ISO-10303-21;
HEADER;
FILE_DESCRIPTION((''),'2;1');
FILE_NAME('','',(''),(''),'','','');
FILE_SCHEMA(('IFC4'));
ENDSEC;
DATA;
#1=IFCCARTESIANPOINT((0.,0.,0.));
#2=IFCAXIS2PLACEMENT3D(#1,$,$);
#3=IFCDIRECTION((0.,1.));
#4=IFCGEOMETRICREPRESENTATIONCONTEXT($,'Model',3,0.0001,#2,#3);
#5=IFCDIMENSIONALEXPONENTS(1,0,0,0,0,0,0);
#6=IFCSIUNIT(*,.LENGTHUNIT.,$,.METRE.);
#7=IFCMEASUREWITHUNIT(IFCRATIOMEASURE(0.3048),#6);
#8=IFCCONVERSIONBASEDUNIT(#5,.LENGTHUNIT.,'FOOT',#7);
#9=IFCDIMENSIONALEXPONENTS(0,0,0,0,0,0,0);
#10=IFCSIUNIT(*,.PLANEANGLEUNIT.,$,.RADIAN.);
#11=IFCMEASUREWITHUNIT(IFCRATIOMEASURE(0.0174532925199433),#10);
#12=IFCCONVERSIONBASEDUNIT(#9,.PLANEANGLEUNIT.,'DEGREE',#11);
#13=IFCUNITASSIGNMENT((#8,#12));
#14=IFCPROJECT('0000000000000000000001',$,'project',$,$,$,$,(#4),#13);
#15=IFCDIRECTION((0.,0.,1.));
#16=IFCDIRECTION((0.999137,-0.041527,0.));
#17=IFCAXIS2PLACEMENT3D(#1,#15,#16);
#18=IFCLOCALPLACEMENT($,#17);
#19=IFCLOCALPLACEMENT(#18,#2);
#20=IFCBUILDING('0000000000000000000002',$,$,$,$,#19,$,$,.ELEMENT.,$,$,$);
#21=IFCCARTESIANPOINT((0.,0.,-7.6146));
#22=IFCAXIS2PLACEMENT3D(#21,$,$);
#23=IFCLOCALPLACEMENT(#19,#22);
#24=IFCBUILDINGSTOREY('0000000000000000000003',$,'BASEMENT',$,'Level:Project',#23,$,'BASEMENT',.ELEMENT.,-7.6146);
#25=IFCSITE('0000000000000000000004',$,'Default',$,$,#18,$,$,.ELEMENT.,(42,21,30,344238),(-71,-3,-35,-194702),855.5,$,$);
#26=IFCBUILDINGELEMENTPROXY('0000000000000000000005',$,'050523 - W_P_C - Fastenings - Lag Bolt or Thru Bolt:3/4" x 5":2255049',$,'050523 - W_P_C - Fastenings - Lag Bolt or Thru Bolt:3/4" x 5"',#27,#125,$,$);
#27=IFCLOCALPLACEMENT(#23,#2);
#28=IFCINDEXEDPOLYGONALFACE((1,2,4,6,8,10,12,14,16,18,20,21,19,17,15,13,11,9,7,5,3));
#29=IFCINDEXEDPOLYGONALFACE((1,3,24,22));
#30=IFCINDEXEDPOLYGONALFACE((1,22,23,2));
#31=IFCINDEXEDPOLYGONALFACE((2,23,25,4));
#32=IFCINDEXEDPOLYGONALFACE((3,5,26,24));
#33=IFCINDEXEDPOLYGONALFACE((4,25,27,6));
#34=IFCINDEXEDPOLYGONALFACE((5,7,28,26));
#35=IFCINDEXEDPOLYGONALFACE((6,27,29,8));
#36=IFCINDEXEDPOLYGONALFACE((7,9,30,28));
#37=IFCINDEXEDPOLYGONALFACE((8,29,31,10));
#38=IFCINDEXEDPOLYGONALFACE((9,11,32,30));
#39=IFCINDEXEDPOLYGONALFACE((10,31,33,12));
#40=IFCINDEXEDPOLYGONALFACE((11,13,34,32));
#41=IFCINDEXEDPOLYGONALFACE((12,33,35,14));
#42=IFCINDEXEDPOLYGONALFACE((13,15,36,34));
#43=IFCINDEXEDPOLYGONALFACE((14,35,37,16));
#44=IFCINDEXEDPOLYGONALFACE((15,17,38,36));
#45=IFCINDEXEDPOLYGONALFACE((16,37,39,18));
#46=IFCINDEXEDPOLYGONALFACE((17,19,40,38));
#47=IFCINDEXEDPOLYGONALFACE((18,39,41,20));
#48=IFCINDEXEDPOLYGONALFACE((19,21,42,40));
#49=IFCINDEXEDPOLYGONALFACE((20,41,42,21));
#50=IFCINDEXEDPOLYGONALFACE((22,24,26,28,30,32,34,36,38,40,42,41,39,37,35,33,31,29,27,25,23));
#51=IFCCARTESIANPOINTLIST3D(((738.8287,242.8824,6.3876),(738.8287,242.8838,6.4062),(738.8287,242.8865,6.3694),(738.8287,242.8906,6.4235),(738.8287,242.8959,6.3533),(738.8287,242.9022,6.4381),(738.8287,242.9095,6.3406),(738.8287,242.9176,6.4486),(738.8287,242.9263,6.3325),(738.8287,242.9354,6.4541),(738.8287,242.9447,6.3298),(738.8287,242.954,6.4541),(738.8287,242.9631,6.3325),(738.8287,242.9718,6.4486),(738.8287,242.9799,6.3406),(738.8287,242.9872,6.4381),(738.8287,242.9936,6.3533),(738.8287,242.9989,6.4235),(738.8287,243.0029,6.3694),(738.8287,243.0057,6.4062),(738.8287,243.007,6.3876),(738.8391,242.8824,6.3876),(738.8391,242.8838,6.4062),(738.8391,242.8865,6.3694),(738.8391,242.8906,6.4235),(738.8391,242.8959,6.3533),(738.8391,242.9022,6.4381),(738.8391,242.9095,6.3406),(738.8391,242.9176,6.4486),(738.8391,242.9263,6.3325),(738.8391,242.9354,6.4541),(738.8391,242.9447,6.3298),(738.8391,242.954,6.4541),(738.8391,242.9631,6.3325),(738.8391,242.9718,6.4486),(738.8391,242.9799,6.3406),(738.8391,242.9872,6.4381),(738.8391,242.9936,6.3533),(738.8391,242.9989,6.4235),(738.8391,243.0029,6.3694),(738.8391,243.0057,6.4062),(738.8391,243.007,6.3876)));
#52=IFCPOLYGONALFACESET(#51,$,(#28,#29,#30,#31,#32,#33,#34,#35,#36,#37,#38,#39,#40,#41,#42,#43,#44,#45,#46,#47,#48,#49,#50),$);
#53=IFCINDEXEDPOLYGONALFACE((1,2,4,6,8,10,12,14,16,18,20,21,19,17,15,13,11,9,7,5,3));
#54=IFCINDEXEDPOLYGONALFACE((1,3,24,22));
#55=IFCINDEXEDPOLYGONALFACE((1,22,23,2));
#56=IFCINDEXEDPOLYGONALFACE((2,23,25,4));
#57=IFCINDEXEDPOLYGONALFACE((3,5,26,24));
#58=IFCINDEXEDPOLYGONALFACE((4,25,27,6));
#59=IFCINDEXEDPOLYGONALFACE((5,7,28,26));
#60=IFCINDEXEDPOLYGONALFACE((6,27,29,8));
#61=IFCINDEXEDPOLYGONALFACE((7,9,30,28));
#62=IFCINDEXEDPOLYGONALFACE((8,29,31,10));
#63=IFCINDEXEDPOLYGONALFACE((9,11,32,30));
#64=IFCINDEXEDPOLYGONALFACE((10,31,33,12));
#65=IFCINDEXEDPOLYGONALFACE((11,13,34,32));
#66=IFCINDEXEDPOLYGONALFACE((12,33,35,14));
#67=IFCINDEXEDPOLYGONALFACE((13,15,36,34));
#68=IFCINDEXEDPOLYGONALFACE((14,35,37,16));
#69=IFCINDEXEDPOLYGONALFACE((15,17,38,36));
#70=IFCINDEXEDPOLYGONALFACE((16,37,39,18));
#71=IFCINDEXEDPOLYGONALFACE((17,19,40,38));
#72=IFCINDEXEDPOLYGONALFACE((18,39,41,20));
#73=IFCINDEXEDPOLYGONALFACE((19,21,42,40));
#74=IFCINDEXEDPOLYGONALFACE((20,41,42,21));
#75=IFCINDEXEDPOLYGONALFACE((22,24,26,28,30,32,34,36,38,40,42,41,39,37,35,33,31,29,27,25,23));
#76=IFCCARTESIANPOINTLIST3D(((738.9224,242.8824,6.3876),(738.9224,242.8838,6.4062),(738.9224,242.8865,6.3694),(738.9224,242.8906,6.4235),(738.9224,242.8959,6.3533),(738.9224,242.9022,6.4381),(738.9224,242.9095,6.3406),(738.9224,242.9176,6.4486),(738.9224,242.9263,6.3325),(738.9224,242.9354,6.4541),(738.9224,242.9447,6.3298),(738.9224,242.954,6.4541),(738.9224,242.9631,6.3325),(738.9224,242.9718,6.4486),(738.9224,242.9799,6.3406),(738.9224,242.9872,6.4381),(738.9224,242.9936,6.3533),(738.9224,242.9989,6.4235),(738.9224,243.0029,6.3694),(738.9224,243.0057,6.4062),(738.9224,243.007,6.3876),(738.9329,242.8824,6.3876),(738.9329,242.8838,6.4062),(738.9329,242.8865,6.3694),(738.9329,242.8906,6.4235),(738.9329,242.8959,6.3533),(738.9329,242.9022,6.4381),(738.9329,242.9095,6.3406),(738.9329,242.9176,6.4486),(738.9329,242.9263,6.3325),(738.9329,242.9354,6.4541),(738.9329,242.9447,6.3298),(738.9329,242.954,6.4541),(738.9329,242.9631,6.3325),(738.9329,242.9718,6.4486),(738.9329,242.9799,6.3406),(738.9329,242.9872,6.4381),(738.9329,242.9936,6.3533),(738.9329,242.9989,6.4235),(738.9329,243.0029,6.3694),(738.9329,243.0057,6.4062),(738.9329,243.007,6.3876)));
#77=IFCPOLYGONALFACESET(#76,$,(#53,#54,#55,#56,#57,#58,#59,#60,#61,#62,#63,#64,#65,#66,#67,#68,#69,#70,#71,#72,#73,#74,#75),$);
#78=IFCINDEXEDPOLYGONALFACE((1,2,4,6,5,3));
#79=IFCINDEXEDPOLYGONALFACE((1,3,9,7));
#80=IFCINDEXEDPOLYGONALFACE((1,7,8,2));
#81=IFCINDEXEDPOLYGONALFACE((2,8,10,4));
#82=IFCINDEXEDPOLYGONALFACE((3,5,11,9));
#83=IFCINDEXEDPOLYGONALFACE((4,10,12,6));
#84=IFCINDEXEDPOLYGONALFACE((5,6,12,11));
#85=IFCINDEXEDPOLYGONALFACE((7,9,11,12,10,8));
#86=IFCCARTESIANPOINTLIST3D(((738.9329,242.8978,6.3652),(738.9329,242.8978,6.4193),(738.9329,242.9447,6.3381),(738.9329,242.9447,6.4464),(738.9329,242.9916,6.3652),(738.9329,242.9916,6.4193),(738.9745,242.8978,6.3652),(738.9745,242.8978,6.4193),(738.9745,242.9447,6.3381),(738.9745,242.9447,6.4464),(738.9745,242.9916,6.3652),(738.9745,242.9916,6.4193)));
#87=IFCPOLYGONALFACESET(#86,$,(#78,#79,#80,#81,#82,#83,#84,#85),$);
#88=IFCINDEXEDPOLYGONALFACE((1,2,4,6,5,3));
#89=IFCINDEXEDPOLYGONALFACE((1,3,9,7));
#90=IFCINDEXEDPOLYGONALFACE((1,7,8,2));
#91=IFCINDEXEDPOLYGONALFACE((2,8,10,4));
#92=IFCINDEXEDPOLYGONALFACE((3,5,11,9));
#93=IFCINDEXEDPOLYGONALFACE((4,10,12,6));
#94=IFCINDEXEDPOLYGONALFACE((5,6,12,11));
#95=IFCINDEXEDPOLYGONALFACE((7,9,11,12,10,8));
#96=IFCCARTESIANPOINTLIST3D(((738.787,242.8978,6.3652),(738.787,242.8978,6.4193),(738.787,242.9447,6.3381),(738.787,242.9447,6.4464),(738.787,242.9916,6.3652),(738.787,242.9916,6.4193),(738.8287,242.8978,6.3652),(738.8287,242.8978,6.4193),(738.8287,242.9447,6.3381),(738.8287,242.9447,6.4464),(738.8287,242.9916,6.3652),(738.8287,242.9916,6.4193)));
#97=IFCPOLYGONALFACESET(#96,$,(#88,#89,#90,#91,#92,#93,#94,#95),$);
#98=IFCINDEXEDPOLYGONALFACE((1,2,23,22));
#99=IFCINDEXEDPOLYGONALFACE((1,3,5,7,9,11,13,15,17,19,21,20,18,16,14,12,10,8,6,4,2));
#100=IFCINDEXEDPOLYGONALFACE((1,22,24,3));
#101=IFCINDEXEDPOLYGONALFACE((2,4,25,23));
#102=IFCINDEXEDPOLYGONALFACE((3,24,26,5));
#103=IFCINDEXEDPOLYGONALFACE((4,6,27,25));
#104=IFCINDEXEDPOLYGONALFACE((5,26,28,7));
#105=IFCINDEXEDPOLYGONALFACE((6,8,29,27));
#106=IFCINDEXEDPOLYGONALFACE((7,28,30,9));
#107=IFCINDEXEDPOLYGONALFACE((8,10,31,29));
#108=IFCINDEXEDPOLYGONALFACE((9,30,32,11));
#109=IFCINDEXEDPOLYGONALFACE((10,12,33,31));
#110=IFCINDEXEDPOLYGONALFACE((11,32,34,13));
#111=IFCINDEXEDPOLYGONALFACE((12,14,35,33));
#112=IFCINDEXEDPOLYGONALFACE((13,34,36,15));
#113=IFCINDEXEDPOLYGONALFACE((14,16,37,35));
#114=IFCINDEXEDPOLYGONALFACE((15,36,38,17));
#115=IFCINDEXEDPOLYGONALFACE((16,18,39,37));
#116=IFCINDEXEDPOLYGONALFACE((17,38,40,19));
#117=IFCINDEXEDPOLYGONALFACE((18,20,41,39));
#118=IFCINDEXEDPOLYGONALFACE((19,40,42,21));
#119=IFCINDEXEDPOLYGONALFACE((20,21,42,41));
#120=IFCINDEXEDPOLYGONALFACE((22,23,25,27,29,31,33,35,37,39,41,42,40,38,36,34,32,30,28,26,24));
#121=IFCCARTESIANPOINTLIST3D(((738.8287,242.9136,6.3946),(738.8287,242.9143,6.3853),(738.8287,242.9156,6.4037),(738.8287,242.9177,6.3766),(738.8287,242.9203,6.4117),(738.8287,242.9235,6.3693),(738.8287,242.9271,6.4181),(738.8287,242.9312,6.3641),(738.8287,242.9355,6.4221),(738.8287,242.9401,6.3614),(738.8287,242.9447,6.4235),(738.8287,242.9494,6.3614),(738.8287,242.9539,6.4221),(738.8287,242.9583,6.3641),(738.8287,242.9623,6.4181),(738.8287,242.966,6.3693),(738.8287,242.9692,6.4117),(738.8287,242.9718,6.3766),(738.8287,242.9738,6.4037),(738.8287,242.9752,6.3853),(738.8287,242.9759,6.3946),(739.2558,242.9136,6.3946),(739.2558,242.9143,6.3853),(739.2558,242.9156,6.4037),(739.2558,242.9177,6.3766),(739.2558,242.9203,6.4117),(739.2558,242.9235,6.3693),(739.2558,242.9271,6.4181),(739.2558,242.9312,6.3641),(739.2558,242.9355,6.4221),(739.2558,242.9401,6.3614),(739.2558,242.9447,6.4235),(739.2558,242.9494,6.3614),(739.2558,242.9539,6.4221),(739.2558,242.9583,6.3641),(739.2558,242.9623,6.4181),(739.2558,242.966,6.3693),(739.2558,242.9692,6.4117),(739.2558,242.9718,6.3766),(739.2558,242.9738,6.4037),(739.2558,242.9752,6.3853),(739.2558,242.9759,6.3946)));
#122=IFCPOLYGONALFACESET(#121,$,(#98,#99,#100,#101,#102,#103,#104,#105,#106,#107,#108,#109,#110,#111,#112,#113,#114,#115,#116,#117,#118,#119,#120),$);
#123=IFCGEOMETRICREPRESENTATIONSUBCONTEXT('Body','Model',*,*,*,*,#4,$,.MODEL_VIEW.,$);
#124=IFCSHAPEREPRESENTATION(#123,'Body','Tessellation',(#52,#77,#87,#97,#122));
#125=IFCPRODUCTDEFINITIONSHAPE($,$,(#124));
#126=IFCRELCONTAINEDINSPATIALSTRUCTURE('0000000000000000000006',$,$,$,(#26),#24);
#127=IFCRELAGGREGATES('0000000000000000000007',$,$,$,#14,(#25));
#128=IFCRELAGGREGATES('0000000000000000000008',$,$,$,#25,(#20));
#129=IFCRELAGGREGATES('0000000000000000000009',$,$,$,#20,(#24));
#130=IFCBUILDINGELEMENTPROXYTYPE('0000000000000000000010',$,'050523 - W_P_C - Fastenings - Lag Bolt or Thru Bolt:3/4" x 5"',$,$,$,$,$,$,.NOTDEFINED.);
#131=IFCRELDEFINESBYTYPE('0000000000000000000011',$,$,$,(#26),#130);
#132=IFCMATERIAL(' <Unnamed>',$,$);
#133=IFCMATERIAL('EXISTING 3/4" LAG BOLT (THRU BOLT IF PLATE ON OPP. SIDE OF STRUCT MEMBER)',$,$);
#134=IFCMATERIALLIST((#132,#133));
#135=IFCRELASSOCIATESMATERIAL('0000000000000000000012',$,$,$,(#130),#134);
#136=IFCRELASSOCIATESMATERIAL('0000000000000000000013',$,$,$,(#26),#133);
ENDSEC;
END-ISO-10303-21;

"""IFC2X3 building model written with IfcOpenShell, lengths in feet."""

from ifc_helpers import new_model, entity, si_unit, converted_unit, direction, frame, frame_2d, origin, place, context, subcontext, project, spatial, polyline, circle, outline, extrude, source, transform, mapped, material, material_list, type_object, type_shapes, element, save


model = new_model("IFC2X3")

# Units and contexts
model_context = context("Model", 3, precision=0.0001, world=origin(), true_north=direction((0.0, 1.0)))
body_context = subcontext(model_context, "Body", "Model", "MODEL_VIEW")
ifc_project = project(units=[converted_unit("LENGTHUNIT", "FOOT", entity("IfcRatioMeasure", 0.3048), si_unit("LENGTHUNIT", "METRE"), dimensions=[1, 0, 0, 0, 0, 0, 0]), converted_unit("PLANEANGLEUNIT", "DEGREE", entity("IfcRatioMeasure", 0.0174532925199433), si_unit("PLANEANGLEUNIT", "RADIAN"), dimensions=[0, 0, 0, 0, 0, 0, 0])], contexts=[model_context])

# Site, building, storey
site_placement = place(None, frame((0.0, 0.0, 0.0), z_axis=(0.0, 0.0, 1.0), x_axis=(0.999137, -0.041527, 0.0)))
site = spatial("IfcSite", under=ifc_project, at=site_placement, Name="Default", CompositionType="ELEMENT", RefLatitude=(42, 21, 30, 344238), RefLongitude=(-71, -3, -35, -194702), RefElevation=855.5)
building_placement = place(site_placement, origin())
building = spatial("IfcBuilding", under=site, at=building_placement, CompositionType="ELEMENT")
storey_placement = place(building_placement, frame((0.0, 0.0, -7.6146)))
storey = spatial("IfcBuildingStorey", under=building, at=storey_placement, Name="BASEMENT", ObjectType="Level:Project", LongName="BASEMENT", CompositionType="ELEMENT", Elevation=-7.6146)

# Building element proxy
ifc_material_1 = material(Name="EXISTING 3/4\" LAG BOLT (THRU BOLT IF PLATE ON OPP. SIDE OF STRUCT MEMBER)")
ifc_material_2 = material(Name=" <Unnamed>")
ifc_material_list_1 = material_list([ifc_material_2, ifc_material_1])
building_element_proxy_type_1 = type_object("IfcBuildingElementProxyType", Name="050523 - W_P_C - Fastenings - Lag Bolt or Thru Bolt:3/4\" x 5\"", PredefinedType="NOTDEFINED", material=ifc_material_list_1)
shared_shape_1 = source(origin(), body_context, "Body", "SweptSolid", [
    extrude(circle(Radius=0.0625, at=frame_2d((0.0, 0.0), x_axis=(1.0, 0.0))), frame((0.0, 0.0, 0.0), z_axis=(0.0, 0.0, 1.0), x_axis=(0.0, -1.0, 0.0)), (0.0, 0.0, 1.0), 0.0104),
    extrude(circle(Radius=0.0625, at=frame_2d((0.0, 0.0), x_axis=(1.0, 0.0))), frame((0.0, 0.0, -0.0938), z_axis=(0.0, 0.0, 1.0), x_axis=(0.0, -1.0, 0.0)), (0.0, 0.0, 1.0), 0.0104),
    extrude(outline(polyline([(-0.0271, -0.0469), (0.0271, -0.0469), (0.0541, 0.0), (0.0271, 0.0469), (-0.0271, 0.0469), (-0.0541, 0.0), (-0.0271, -0.0469)])), frame((0.0, 0.0, -0.1354), z_axis=(0.0, 0.0, 1.0), x_axis=(0.866025, -0.5, 0.0)), (0.0, 0.0, 1.0), 0.0417),
    extrude(outline(polyline([(-0.0271, -0.0469), (0.0271, -0.0469), (0.0541, 0.0), (0.0271, 0.0469), (-0.0271, 0.0469), (-0.0541, 0.0), (-0.0271, -0.0469)])), frame((0.0, 0.0, 0.0104), z_axis=(0.0, 0.0, 1.0), x_axis=(0.0, -1.0, 0.0)), (0.0, 0.0, 1.0), 0.0417),
    extrude(circle(Radius=0.0312, at=frame_2d((0.0, 0.0), x_axis=(1.0, 0.0))), frame((0.0, 0.0, -0.4167), z_axis=(0.0, 0.0, 1.0), x_axis=(0.0, 1.0, 0.0)), (0.0, 0.0, 1.0), 0.4271),
])
type_shapes(building_element_proxy_type_1, [shared_shape_1])
for number, where, z_axis, x_axis, name in (
    (1, (738.8391, 242.9447, 6.3923), (-1.0, 0.0, 0.0), (0.0, -1.0, 0.0), "050523 - W_P_C - Fastenings - Lag Bolt or Thru Bolt:3/4\" x 5\":2255049"),
):
    element("IfcBuildingElementProxy", number, at=place(storey_placement, frame(where, z_axis=z_axis, x_axis=x_axis)), inside=storey, type_object=building_element_proxy_type_1, material=ifc_material_1, Name=name, ObjectType="050523 - W_P_C - Fastenings - Lag Bolt or Thru Bolt:3/4\" x 5\"", context=body_context, shape_type="MappedRepresentation", body=[
        mapped(shared_shape_1, transform((0.0, 0.0, 0.0), scale=1.0)),
    ])

save(model, "model.ifc")
